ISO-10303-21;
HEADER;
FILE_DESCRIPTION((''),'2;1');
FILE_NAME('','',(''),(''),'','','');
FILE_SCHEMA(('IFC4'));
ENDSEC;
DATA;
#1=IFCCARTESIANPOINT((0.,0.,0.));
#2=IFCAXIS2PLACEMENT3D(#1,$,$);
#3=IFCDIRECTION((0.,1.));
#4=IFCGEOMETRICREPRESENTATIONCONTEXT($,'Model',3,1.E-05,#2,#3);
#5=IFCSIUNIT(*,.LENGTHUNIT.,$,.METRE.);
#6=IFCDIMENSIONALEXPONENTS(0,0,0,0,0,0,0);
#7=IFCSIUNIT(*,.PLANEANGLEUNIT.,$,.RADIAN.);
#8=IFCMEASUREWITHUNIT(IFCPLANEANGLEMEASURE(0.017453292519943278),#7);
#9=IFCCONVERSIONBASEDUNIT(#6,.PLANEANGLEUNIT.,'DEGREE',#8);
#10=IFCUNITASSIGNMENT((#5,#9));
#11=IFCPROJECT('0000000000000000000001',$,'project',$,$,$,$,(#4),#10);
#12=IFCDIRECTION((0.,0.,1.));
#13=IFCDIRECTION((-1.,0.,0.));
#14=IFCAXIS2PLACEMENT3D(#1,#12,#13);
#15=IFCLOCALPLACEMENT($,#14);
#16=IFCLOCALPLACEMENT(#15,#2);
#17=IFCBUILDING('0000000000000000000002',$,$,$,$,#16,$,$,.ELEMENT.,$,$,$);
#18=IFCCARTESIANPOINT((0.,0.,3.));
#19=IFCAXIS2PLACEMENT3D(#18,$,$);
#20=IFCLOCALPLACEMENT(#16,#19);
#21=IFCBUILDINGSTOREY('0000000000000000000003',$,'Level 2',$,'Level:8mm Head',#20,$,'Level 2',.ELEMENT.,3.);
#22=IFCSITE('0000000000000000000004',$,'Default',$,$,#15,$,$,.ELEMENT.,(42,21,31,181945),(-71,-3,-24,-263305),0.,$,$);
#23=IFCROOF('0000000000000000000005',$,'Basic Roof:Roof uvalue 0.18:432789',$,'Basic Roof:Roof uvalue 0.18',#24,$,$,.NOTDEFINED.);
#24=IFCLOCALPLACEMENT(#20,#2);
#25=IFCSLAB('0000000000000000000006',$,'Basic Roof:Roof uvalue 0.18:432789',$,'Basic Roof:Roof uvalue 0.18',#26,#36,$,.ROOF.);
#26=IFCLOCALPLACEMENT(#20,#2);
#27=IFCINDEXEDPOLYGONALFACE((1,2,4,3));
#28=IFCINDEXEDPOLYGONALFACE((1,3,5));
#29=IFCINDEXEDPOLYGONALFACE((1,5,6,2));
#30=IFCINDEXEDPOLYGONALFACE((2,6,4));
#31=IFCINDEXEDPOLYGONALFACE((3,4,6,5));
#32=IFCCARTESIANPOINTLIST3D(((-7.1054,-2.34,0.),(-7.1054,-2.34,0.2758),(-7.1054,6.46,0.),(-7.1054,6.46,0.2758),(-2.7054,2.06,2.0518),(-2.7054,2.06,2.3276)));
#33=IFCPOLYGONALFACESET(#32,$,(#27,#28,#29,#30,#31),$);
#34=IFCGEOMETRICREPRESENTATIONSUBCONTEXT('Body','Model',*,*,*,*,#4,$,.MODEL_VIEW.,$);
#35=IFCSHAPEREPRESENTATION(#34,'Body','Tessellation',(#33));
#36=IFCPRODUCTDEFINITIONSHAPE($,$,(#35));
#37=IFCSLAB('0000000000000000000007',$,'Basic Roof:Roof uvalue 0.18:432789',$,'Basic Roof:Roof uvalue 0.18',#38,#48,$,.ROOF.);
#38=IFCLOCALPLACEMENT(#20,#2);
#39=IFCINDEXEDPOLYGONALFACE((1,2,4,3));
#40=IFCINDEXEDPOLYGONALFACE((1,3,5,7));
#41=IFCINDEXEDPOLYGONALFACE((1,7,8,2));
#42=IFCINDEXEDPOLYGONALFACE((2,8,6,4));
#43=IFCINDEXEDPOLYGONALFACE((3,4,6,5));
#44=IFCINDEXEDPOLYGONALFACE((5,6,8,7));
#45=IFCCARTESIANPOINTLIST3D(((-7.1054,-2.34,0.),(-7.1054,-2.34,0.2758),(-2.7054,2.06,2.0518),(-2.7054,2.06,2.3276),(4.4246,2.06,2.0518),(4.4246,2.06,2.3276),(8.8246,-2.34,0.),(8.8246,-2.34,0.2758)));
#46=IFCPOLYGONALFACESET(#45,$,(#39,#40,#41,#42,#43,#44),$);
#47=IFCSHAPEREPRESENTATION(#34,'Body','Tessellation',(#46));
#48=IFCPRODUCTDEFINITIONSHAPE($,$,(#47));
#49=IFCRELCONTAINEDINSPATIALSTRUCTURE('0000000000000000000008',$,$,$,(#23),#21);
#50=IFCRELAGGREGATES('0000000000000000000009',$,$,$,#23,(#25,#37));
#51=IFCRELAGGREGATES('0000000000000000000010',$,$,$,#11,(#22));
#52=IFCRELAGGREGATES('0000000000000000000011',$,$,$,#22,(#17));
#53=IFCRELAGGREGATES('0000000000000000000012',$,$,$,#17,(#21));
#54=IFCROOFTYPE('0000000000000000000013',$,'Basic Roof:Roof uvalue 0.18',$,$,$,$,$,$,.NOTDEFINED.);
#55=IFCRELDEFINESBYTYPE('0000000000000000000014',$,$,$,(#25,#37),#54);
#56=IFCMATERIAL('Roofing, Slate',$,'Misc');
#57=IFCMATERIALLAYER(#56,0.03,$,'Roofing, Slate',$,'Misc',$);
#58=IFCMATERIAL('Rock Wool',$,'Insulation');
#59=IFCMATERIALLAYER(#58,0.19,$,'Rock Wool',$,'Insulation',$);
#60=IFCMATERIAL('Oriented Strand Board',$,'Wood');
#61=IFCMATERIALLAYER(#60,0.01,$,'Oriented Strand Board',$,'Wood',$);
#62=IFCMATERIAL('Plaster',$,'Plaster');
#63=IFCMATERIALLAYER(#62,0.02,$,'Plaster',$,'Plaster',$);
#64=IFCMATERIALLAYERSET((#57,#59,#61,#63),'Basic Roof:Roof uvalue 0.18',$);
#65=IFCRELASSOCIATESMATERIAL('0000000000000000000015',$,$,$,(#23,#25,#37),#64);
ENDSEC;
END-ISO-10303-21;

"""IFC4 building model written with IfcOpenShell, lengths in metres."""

from ifc_helpers import new_model, entity, si_unit, converted_unit, direction, frame, origin, place, context, subcontext, project, spatial, polyline, outline, extrude, material, layer, layer_set, type_object, element, aggregate, save


model = new_model("IFC4")

# Units and contexts
model_context = context("Model", 3, precision=1e-05, world=origin(), true_north=direction((0.0, 1.0)))
body_context = subcontext(model_context, "Body", "Model", "MODEL_VIEW")
ifc_project = project(units=[si_unit("LENGTHUNIT", "METRE"), converted_unit("PLANEANGLEUNIT", "DEGREE", entity("IfcPlaneAngleMeasure", 0.017453292519943278), si_unit("PLANEANGLEUNIT", "RADIAN"), dimensions=[0, 0, 0, 0, 0, 0, 0])], contexts=[model_context])

# Site, building, storey
site_placement = place(None, frame((0.0, 0.0, 0.0), z_axis=(0.0, 0.0, 1.0), x_axis=(-1.0, 0.0, 0.0)))
site = spatial("IfcSite", under=ifc_project, at=site_placement, Name="Default", CompositionType="ELEMENT", RefLatitude=(42, 21, 31, 181945), RefLongitude=(-71, -3, -24, -263305), RefElevation=0.0)
building_placement = place(site_placement, origin())
building = spatial("IfcBuilding", under=site, at=building_placement, CompositionType="ELEMENT")
storey_placement = place(building_placement, frame((0.0, 0.0, 3.0)))
storey = spatial("IfcBuildingStorey", under=building, at=storey_placement, Name="Level 2", ObjectType="Level:8mm Head", LongName="Level 2", CompositionType="ELEMENT", Elevation=3.0)

# Roof, slabs
ifc_material_1 = material(Name="Roofing, Slate", Category="Misc")
ifc_layer_1 = layer(ifc_material_1, 0.03, Name="Roofing, Slate", Category="Misc")
ifc_material_2 = material(Name="Rock Wool", Category="Insulation")
ifc_layer_2 = layer(ifc_material_2, 0.19, Name="Rock Wool", Category="Insulation")
ifc_material_3 = material(Name="Oriented Strand Board", Category="Wood")
ifc_layer_3 = layer(ifc_material_3, 0.01, Name="Oriented Strand Board", Category="Wood")
ifc_material_4 = material(Name="Plaster", Category="Plaster")
ifc_layer_4 = layer(ifc_material_4, 0.02, Name="Plaster", Category="Plaster")
ifc_layer_set = layer_set([ifc_layer_1, ifc_layer_2, ifc_layer_3, ifc_layer_4], Name="Basic Roof:Roof uvalue 0.18")
roof_placement = place(storey_placement, frame((-7.1054, -2.34, 0.0)))
roof = element("IfcRoof", 1, at=roof_placement, inside=storey, material=ifc_layer_set, Name="Basic Roof:Roof uvalue 0.18:432789", ObjectType="Basic Roof:Roof uvalue 0.18", PredefinedType="NOTDEFINED")
roof_type = type_object("IfcRoofType", Name="Basic Roof:Roof uvalue 0.18", PredefinedType="NOTDEFINED")
slab_1_placement = place(roof_placement, origin())
slab_1 = element("IfcSlab", 2, at=slab_1_placement, type_object=roof_type, material=ifc_layer_set, Name="Basic Roof:Roof uvalue 0.18:432789", ObjectType="Basic Roof:Roof uvalue 0.18", PredefinedType="ROOF", context=body_context, shape_type="SweptSolid", body=[
    extrude(outline(polyline([(-2.4274, 4.4), (-2.4274, -4.4), (2.4274, 0.0), (-2.4274, 4.4)])), frame((2.2, 4.4, 1.0259), z_axis=(-0.422618, 0.0, 0.906308), x_axis=(0.906308, 0.0, 0.422618)), (0.422618, 0.0, 0.906308), 0.2758),
])
slab_2_placement = place(roof_placement, origin())
slab_2 = element("IfcSlab", 3, at=slab_2_placement, type_object=roof_type, material=ifc_layer_set, Name="Basic Roof:Roof uvalue 0.18:432789", ObjectType="Basic Roof:Roof uvalue 0.18", PredefinedType="ROOF", context=body_context, shape_type="SweptSolid", body=[
    extrude(outline(polyline([(-7.965, -2.4274), (7.965, -2.4274), (3.565, 2.4274), (-3.565, 2.4274), (-7.965, -2.4274)])), frame((7.965, 2.2, 1.0259), z_axis=(0.0, -0.422618, 0.906308), x_axis=(1.0, 0.0, 0.0)), (0.0, 0.422618, 0.906308), 0.2758),
])
aggregate(roof, [slab_1, slab_2])

save(model, "model.ifc")
